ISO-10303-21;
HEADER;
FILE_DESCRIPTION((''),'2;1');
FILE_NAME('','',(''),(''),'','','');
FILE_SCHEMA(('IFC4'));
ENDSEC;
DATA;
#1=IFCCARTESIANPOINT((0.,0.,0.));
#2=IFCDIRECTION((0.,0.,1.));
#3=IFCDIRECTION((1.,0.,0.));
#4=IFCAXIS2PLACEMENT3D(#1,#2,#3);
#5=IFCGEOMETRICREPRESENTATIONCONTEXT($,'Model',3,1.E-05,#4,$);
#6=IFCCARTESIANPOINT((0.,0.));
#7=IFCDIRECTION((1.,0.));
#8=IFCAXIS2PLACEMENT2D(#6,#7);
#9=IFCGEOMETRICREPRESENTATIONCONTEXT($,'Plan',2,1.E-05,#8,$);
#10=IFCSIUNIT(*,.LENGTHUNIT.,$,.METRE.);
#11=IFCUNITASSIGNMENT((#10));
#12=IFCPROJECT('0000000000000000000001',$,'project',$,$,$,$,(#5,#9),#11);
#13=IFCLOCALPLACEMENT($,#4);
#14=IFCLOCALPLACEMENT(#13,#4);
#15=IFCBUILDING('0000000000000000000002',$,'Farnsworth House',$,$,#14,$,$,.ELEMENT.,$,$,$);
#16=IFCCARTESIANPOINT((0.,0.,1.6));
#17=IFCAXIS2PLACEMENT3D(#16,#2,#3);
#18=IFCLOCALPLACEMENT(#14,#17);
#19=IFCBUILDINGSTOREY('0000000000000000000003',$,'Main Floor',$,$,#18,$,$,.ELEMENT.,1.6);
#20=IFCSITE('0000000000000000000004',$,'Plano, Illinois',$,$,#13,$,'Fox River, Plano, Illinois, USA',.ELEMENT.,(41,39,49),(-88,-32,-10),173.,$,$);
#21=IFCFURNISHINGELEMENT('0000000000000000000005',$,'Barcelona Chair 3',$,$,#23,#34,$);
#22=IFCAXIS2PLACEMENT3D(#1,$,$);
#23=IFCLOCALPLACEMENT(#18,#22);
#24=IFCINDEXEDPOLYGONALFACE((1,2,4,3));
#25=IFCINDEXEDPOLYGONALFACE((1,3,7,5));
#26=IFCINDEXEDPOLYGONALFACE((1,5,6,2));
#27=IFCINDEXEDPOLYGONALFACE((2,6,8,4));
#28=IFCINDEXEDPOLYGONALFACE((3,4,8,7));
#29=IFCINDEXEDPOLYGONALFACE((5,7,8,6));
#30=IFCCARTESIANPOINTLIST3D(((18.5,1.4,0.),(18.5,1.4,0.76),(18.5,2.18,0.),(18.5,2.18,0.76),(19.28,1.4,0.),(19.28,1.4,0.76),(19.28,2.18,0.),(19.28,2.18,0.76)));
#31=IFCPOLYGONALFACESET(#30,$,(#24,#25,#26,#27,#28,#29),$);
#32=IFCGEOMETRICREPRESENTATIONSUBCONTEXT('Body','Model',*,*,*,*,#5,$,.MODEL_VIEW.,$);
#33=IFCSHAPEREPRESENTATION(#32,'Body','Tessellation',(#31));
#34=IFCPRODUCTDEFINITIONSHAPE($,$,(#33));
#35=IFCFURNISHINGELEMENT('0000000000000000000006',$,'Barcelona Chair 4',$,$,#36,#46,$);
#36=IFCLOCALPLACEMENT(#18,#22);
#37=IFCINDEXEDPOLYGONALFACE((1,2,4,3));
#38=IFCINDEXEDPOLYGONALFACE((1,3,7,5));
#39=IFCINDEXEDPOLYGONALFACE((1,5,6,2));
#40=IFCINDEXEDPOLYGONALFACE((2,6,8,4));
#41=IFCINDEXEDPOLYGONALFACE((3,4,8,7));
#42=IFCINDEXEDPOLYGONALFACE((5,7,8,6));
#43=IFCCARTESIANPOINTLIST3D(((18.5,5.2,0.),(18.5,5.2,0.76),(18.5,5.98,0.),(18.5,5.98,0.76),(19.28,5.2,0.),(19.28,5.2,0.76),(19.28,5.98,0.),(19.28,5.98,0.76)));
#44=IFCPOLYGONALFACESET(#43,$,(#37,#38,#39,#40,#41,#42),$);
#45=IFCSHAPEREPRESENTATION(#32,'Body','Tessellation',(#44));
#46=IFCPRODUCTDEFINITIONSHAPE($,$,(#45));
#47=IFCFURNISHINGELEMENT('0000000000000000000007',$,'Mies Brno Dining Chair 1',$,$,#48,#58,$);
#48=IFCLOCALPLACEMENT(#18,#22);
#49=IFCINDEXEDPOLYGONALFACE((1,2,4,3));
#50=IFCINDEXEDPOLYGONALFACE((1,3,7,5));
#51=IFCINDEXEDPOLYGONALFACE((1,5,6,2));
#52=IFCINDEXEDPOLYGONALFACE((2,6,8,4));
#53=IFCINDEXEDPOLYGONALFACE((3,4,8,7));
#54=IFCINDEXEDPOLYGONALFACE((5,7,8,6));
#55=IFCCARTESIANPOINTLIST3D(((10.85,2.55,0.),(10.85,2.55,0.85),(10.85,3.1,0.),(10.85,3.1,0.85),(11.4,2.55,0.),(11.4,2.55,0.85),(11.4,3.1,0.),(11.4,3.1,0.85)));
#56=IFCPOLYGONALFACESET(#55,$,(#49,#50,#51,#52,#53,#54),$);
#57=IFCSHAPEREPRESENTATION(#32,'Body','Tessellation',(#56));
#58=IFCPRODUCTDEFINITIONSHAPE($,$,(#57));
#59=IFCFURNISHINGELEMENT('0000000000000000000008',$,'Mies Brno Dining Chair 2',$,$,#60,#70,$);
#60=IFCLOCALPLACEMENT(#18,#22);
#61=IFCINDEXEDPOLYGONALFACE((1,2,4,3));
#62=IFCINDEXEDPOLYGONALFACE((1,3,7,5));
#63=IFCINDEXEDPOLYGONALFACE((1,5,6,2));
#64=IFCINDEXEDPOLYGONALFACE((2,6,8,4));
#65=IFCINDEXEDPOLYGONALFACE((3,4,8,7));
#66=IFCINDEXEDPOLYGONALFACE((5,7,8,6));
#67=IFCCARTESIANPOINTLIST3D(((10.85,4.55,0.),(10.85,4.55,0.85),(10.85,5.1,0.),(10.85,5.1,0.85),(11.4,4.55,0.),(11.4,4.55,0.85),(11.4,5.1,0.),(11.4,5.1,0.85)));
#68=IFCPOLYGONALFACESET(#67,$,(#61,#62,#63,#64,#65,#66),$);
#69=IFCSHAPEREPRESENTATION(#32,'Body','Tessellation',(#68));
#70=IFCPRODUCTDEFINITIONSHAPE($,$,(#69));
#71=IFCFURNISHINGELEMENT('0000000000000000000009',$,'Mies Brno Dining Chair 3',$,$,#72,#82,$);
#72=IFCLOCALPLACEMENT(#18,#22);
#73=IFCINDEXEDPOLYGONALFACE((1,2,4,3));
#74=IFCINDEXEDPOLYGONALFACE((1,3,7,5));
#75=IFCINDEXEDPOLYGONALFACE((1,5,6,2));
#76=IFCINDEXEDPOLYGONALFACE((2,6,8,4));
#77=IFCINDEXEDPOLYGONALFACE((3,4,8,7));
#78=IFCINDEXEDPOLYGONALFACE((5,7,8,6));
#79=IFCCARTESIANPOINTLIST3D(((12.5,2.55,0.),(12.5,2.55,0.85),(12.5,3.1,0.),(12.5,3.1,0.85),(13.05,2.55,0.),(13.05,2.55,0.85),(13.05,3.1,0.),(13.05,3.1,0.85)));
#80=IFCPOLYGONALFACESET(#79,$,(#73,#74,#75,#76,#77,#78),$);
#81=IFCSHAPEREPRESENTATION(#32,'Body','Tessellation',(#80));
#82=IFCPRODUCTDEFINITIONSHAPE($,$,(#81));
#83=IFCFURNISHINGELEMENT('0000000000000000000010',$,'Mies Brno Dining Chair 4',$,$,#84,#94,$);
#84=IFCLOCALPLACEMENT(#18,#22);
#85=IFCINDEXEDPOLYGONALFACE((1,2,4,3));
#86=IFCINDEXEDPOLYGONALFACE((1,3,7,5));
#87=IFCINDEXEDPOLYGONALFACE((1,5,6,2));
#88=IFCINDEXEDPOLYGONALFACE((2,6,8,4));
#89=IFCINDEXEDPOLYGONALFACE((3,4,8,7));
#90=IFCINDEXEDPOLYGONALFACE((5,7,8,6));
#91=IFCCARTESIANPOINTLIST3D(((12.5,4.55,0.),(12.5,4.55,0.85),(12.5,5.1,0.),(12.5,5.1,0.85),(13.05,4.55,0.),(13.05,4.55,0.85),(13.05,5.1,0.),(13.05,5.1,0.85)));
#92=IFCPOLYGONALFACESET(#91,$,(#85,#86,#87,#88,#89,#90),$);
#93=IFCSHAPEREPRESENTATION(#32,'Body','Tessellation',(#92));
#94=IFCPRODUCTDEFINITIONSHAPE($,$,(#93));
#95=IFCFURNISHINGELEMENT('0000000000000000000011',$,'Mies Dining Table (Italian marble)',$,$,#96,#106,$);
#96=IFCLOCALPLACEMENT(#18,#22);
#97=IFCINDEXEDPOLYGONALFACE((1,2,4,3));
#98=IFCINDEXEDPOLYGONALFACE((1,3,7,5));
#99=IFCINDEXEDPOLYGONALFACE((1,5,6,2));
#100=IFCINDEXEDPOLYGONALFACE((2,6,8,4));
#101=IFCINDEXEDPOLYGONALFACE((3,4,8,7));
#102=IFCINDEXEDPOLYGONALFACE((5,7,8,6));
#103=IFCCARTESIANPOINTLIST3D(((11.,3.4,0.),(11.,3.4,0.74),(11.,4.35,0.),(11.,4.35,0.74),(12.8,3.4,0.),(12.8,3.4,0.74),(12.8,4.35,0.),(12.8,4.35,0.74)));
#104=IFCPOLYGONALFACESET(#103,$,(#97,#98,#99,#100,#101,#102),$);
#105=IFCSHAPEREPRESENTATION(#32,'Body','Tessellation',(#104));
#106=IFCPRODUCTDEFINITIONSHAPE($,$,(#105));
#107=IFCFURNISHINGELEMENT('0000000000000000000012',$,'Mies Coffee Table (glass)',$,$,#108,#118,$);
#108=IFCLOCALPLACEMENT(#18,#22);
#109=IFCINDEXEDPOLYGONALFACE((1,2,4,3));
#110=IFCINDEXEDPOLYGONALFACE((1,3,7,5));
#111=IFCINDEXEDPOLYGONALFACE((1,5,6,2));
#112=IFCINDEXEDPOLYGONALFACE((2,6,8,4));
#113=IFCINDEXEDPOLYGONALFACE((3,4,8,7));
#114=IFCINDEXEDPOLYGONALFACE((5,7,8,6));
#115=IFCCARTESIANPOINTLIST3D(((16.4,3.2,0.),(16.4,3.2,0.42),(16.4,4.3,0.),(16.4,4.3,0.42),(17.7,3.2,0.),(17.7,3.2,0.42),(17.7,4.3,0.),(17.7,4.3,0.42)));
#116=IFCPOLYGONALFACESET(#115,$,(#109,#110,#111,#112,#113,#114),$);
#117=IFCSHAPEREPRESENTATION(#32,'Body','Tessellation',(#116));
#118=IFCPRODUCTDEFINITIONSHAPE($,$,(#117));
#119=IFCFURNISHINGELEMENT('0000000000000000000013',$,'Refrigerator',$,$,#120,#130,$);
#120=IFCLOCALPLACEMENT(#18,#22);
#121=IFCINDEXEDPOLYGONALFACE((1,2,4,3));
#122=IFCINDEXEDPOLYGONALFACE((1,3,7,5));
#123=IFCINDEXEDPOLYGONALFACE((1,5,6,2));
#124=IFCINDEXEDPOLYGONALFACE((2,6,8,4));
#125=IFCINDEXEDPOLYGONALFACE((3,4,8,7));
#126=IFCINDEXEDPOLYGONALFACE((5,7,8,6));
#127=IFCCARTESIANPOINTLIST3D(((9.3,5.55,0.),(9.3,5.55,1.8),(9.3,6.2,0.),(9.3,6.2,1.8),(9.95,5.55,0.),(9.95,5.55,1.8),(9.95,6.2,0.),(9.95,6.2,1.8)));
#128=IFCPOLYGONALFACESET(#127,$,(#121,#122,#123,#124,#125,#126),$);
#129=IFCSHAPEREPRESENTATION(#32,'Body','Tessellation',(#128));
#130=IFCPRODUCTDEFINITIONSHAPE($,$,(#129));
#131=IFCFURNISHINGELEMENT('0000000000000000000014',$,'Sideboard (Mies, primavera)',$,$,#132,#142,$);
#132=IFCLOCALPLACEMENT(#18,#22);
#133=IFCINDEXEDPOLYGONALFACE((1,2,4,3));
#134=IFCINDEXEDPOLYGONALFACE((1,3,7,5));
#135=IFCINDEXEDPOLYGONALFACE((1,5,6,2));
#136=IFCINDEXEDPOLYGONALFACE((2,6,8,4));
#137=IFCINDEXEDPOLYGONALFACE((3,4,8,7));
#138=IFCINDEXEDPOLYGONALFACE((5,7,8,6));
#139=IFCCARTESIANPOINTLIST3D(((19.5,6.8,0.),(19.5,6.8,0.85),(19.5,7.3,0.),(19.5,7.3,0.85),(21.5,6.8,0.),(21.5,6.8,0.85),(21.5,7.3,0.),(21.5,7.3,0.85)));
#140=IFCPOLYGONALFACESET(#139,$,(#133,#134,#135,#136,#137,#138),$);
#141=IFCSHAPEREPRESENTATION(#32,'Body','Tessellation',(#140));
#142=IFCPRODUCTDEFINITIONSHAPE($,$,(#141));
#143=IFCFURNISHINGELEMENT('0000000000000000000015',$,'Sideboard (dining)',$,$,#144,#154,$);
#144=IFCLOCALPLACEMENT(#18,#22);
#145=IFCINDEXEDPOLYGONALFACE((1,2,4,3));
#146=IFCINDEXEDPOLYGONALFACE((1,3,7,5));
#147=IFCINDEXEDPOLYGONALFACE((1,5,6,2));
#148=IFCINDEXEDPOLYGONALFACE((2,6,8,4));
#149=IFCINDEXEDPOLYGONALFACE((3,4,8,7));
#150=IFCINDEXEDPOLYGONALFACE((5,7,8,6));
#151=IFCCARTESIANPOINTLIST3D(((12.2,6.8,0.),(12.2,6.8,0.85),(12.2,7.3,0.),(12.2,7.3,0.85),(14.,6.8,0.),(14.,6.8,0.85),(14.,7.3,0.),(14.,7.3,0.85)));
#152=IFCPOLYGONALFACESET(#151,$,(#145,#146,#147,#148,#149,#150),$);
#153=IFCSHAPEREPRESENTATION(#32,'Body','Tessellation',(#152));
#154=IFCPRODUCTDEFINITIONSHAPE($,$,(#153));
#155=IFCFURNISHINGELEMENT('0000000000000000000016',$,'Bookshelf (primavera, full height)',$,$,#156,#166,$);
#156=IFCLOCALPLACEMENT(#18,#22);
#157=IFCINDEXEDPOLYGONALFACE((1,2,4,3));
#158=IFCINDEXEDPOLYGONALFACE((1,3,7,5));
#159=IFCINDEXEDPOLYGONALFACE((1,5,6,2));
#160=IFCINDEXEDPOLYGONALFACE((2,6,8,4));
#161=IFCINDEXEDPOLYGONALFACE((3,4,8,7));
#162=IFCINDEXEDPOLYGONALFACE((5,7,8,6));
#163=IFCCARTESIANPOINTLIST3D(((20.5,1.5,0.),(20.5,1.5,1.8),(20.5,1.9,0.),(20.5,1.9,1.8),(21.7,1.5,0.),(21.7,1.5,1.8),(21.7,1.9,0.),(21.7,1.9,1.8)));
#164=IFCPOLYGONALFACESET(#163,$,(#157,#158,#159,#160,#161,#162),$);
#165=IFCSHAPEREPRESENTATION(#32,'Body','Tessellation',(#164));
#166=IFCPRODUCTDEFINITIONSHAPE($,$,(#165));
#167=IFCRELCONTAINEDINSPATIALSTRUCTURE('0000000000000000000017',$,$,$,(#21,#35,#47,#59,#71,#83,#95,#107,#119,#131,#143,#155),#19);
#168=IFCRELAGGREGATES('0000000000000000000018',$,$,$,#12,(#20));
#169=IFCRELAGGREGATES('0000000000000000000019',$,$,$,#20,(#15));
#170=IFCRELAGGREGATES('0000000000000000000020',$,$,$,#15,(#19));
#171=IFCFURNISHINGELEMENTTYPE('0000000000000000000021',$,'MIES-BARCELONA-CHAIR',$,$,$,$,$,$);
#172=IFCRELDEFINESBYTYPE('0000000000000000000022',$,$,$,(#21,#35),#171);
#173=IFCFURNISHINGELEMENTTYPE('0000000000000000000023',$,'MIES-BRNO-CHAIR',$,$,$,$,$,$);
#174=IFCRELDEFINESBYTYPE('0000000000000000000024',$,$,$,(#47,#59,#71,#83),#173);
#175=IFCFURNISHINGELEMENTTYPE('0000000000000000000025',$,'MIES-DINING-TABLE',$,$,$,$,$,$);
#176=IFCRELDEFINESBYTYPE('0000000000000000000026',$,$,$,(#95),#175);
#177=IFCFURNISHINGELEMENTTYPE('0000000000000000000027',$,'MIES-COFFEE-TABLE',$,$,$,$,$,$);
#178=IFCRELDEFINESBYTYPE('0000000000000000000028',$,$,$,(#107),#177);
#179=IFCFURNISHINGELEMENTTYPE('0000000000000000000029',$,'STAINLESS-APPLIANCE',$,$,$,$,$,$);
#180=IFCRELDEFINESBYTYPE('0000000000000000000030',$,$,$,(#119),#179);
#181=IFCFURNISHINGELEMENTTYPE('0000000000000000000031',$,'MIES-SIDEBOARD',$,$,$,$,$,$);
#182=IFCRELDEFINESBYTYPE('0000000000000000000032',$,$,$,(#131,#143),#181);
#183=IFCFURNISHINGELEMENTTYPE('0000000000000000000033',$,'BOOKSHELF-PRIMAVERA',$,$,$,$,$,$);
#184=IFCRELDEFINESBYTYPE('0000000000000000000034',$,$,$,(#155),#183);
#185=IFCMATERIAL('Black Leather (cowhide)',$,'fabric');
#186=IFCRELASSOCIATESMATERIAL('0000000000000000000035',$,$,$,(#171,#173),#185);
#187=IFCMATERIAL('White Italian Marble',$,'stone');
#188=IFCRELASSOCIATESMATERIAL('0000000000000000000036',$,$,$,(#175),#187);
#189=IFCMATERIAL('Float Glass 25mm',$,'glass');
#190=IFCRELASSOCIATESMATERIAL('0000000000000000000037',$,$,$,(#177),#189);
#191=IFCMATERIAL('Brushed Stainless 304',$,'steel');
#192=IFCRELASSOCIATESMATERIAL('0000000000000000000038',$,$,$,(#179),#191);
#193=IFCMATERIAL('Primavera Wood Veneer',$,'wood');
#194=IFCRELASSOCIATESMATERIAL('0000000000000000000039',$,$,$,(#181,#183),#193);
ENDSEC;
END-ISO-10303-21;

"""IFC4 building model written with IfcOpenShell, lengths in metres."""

from ifc_helpers import new_model, si_unit, frame, origin_with_axes, origin_2d_with_axis, place, context, subcontext, project, spatial, rectangle, extrude, material, type_object, element, save


model = new_model("IFC4")

# Units and contexts
model_context = context("Model", 3, precision=1e-05, world=origin_with_axes())
plan_context = context("Plan", 2, precision=1e-05, world=origin_2d_with_axis())
body_context = subcontext(model_context, "Body", "Model", "MODEL_VIEW")
ifc_project = project(units=[si_unit("LENGTHUNIT", "METRE")], contexts=[model_context, plan_context])

# Site, building, storey
site_placement = place(None, origin_with_axes())
site = spatial("IfcSite", under=ifc_project, at=site_placement, Name="Plano, Illinois", LongName="Fox River, Plano, Illinois, USA", CompositionType="ELEMENT", RefLatitude=(41, 39, 49), RefLongitude=(-88, -32, -10), RefElevation=173.0)
building_placement = place(site_placement, origin_with_axes())
building = spatial("IfcBuilding", under=site, at=building_placement, Name="Farnsworth House", CompositionType="ELEMENT")
storey_placement = place(building_placement, frame((0.0, 0.0, 1.6), z_axis=(0.0, 0.0, 1.0), x_axis=(1.0, 0.0, 0.0)))
storey = spatial("IfcBuildingStorey", under=building, at=storey_placement, Name="Main Floor", CompositionType="ELEMENT", Elevation=1.6)

# Shared definitions
ifc_material_1 = material(Name="Float Glass 25mm", Category="glass")

# Furnishing elements
ifc_material_2 = material(Name="Black Leather (cowhide)", Category="fabric")
furnishing_element_type_1 = type_object("IfcFurnishingElementType", Name="MIES-BARCELONA-CHAIR", material=ifc_material_2)
for number, where, z_axis, x_axis, name in (
    (1, (18.5, 1.4, 0.0), (0.0, 0.0, 1.0), (1.0, 0.0, 0.0), "Barcelona Chair 3"),
    (2, (18.5, 5.2, 0.0), (0.0, 0.0, 1.0), (1.0, 0.0, 0.0), "Barcelona Chair 4"),
):
    element("IfcFurnishingElement", number, at=place(storey_placement, frame(where, z_axis=z_axis, x_axis=x_axis)), inside=storey, type_object=furnishing_element_type_1, Name=name, context=body_context, shape_type="SweptSolid", body=[
        extrude(rectangle(XDim=0.78, YDim=0.78, at=origin_2d_with_axis()), frame((0.39, 0.39, 0.0), z_axis=(0.0, 0.0, 1.0), x_axis=(1.0, 0.0, 0.0)), (0.0, 0.0, 1.0), 0.76),
    ])
furnishing_element_type_2 = type_object("IfcFurnishingElementType", Name="MIES-BRNO-CHAIR", material=ifc_material_2)
for number, where, z_axis, x_axis, name in (
    (3, (10.85, 2.55, 0.0), (0.0, 0.0, 1.0), (1.0, 0.0, 0.0), "Mies Brno Dining Chair 1"),
    (4, (10.85, 4.55, 0.0), (0.0, 0.0, 1.0), (1.0, 0.0, 0.0), "Mies Brno Dining Chair 2"),
    (5, (12.5, 2.55, 0.0), (0.0, 0.0, 1.0), (1.0, 0.0, 0.0), "Mies Brno Dining Chair 3"),
    (6, (12.5, 4.55, 0.0), (0.0, 0.0, 1.0), (1.0, 0.0, 0.0), "Mies Brno Dining Chair 4"),
):
    element("IfcFurnishingElement", number, at=place(storey_placement, frame(where, z_axis=z_axis, x_axis=x_axis)), inside=storey, type_object=furnishing_element_type_2, Name=name, context=body_context, shape_type="SweptSolid", body=[
        extrude(rectangle(XDim=0.55, YDim=0.55, at=origin_2d_with_axis()), frame((0.275, 0.275, 0.0), z_axis=(0.0, 0.0, 1.0), x_axis=(1.0, 0.0, 0.0)), (0.0, 0.0, 1.0), 0.85),
    ])
ifc_material_3 = material(Name="White Italian Marble", Category="stone")
furnishing_element_type_3 = type_object("IfcFurnishingElementType", Name="MIES-DINING-TABLE", material=ifc_material_3)
furnishing_1_placement = place(storey_placement, frame((11.0, 3.4, 0.0), z_axis=(0.0, 0.0, 1.0), x_axis=(1.0, 0.0, 0.0)))
element("IfcFurnishingElement", 7, at=furnishing_1_placement, inside=storey, type_object=furnishing_element_type_3, Name="Mies Dining Table (Italian marble)", context=body_context, shape_type="SweptSolid", body=[
    extrude(rectangle(XDim=1.8, YDim=0.95, at=origin_2d_with_axis()), frame((0.9, 0.475, 0.0), z_axis=(0.0, 0.0, 1.0), x_axis=(1.0, 0.0, 0.0)), (0.0, 0.0, 1.0), 0.74),
])
furnishing_element_type_4 = type_object("IfcFurnishingElementType", Name="MIES-COFFEE-TABLE", material=ifc_material_1)
furnishing_2_placement = place(storey_placement, frame((16.4, 3.2, 0.0), z_axis=(0.0, 0.0, 1.0), x_axis=(1.0, 0.0, 0.0)))
element("IfcFurnishingElement", 8, at=furnishing_2_placement, inside=storey, type_object=furnishing_element_type_4, Name="Mies Coffee Table (glass)", context=body_context, shape_type="SweptSolid", body=[
    extrude(rectangle(XDim=1.3, YDim=1.1, at=origin_2d_with_axis()), frame((0.65, 0.55, 0.0), z_axis=(0.0, 0.0, 1.0), x_axis=(1.0, 0.0, 0.0)), (0.0, 0.0, 1.0), 0.42),
])
ifc_material_4 = material(Name="Brushed Stainless 304", Category="steel")
furnishing_element_type_5 = type_object("IfcFurnishingElementType", Name="STAINLESS-APPLIANCE", material=ifc_material_4)
furnishing_3_placement = place(storey_placement, frame((9.3, 5.55, 0.0), z_axis=(0.0, 0.0, 1.0), x_axis=(1.0, 0.0, 0.0)))
element("IfcFurnishingElement", 9, at=furnishing_3_placement, inside=storey, type_object=furnishing_element_type_5, Name="Refrigerator", context=body_context, shape_type="SweptSolid", body=[
    extrude(rectangle(XDim=0.65, YDim=0.65, at=origin_2d_with_axis()), frame((0.325, 0.325, 0.0), z_axis=(0.0, 0.0, 1.0), x_axis=(1.0, 0.0, 0.0)), (0.0, 0.0, 1.0), 1.8),
])
ifc_material_5 = material(Name="Primavera Wood Veneer", Category="wood")
furnishing_element_type_6 = type_object("IfcFurnishingElementType", Name="MIES-SIDEBOARD", material=ifc_material_5)
furnishing_4_placement = place(storey_placement, frame((19.5, 6.8, 0.0), z_axis=(0.0, 0.0, 1.0), x_axis=(1.0, 0.0, 0.0)))
element("IfcFurnishingElement", 10, at=furnishing_4_placement, inside=storey, type_object=furnishing_element_type_6, Name="Sideboard (Mies, primavera)", context=body_context, shape_type="SweptSolid", body=[
    extrude(rectangle(XDim=2.0, YDim=0.5, at=origin_2d_with_axis()), frame((1.0, 0.25, 0.0), z_axis=(0.0, 0.0, 1.0), x_axis=(1.0, 0.0, 0.0)), (0.0, 0.0, 1.0), 0.85),
])
furnishing_5_placement = place(storey_placement, frame((12.2, 6.8, 0.0), z_axis=(0.0, 0.0, 1.0), x_axis=(1.0, 0.0, 0.0)))
element("IfcFurnishingElement", 11, at=furnishing_5_placement, inside=storey, type_object=furnishing_element_type_6, Name="Sideboard (dining)", context=body_context, shape_type="SweptSolid", body=[
    extrude(rectangle(XDim=1.8, YDim=0.5, at=origin_2d_with_axis()), frame((0.9, 0.25, 0.0), z_axis=(0.0, 0.0, 1.0), x_axis=(1.0, 0.0, 0.0)), (0.0, 0.0, 1.0), 0.85),
])
furnishing_element_type_7 = type_object("IfcFurnishingElementType", Name="BOOKSHELF-PRIMAVERA", material=ifc_material_5)
furnishing_6_placement = place(storey_placement, frame((20.5, 1.5, 0.0), z_axis=(0.0, 0.0, 1.0), x_axis=(1.0, 0.0, 0.0)))
element("IfcFurnishingElement", 12, at=furnishing_6_placement, inside=storey, type_object=furnishing_element_type_7, Name="Bookshelf (primavera, full height)", context=body_context, shape_type="SweptSolid", body=[
    extrude(rectangle(XDim=1.2, YDim=0.4, at=origin_2d_with_axis()), frame((0.6, 0.2, 0.0), z_axis=(0.0, 0.0, 1.0), x_axis=(1.0, 0.0, 0.0)), (0.0, 0.0, 1.0), 1.8),
])

save(model, "model.ifc")
